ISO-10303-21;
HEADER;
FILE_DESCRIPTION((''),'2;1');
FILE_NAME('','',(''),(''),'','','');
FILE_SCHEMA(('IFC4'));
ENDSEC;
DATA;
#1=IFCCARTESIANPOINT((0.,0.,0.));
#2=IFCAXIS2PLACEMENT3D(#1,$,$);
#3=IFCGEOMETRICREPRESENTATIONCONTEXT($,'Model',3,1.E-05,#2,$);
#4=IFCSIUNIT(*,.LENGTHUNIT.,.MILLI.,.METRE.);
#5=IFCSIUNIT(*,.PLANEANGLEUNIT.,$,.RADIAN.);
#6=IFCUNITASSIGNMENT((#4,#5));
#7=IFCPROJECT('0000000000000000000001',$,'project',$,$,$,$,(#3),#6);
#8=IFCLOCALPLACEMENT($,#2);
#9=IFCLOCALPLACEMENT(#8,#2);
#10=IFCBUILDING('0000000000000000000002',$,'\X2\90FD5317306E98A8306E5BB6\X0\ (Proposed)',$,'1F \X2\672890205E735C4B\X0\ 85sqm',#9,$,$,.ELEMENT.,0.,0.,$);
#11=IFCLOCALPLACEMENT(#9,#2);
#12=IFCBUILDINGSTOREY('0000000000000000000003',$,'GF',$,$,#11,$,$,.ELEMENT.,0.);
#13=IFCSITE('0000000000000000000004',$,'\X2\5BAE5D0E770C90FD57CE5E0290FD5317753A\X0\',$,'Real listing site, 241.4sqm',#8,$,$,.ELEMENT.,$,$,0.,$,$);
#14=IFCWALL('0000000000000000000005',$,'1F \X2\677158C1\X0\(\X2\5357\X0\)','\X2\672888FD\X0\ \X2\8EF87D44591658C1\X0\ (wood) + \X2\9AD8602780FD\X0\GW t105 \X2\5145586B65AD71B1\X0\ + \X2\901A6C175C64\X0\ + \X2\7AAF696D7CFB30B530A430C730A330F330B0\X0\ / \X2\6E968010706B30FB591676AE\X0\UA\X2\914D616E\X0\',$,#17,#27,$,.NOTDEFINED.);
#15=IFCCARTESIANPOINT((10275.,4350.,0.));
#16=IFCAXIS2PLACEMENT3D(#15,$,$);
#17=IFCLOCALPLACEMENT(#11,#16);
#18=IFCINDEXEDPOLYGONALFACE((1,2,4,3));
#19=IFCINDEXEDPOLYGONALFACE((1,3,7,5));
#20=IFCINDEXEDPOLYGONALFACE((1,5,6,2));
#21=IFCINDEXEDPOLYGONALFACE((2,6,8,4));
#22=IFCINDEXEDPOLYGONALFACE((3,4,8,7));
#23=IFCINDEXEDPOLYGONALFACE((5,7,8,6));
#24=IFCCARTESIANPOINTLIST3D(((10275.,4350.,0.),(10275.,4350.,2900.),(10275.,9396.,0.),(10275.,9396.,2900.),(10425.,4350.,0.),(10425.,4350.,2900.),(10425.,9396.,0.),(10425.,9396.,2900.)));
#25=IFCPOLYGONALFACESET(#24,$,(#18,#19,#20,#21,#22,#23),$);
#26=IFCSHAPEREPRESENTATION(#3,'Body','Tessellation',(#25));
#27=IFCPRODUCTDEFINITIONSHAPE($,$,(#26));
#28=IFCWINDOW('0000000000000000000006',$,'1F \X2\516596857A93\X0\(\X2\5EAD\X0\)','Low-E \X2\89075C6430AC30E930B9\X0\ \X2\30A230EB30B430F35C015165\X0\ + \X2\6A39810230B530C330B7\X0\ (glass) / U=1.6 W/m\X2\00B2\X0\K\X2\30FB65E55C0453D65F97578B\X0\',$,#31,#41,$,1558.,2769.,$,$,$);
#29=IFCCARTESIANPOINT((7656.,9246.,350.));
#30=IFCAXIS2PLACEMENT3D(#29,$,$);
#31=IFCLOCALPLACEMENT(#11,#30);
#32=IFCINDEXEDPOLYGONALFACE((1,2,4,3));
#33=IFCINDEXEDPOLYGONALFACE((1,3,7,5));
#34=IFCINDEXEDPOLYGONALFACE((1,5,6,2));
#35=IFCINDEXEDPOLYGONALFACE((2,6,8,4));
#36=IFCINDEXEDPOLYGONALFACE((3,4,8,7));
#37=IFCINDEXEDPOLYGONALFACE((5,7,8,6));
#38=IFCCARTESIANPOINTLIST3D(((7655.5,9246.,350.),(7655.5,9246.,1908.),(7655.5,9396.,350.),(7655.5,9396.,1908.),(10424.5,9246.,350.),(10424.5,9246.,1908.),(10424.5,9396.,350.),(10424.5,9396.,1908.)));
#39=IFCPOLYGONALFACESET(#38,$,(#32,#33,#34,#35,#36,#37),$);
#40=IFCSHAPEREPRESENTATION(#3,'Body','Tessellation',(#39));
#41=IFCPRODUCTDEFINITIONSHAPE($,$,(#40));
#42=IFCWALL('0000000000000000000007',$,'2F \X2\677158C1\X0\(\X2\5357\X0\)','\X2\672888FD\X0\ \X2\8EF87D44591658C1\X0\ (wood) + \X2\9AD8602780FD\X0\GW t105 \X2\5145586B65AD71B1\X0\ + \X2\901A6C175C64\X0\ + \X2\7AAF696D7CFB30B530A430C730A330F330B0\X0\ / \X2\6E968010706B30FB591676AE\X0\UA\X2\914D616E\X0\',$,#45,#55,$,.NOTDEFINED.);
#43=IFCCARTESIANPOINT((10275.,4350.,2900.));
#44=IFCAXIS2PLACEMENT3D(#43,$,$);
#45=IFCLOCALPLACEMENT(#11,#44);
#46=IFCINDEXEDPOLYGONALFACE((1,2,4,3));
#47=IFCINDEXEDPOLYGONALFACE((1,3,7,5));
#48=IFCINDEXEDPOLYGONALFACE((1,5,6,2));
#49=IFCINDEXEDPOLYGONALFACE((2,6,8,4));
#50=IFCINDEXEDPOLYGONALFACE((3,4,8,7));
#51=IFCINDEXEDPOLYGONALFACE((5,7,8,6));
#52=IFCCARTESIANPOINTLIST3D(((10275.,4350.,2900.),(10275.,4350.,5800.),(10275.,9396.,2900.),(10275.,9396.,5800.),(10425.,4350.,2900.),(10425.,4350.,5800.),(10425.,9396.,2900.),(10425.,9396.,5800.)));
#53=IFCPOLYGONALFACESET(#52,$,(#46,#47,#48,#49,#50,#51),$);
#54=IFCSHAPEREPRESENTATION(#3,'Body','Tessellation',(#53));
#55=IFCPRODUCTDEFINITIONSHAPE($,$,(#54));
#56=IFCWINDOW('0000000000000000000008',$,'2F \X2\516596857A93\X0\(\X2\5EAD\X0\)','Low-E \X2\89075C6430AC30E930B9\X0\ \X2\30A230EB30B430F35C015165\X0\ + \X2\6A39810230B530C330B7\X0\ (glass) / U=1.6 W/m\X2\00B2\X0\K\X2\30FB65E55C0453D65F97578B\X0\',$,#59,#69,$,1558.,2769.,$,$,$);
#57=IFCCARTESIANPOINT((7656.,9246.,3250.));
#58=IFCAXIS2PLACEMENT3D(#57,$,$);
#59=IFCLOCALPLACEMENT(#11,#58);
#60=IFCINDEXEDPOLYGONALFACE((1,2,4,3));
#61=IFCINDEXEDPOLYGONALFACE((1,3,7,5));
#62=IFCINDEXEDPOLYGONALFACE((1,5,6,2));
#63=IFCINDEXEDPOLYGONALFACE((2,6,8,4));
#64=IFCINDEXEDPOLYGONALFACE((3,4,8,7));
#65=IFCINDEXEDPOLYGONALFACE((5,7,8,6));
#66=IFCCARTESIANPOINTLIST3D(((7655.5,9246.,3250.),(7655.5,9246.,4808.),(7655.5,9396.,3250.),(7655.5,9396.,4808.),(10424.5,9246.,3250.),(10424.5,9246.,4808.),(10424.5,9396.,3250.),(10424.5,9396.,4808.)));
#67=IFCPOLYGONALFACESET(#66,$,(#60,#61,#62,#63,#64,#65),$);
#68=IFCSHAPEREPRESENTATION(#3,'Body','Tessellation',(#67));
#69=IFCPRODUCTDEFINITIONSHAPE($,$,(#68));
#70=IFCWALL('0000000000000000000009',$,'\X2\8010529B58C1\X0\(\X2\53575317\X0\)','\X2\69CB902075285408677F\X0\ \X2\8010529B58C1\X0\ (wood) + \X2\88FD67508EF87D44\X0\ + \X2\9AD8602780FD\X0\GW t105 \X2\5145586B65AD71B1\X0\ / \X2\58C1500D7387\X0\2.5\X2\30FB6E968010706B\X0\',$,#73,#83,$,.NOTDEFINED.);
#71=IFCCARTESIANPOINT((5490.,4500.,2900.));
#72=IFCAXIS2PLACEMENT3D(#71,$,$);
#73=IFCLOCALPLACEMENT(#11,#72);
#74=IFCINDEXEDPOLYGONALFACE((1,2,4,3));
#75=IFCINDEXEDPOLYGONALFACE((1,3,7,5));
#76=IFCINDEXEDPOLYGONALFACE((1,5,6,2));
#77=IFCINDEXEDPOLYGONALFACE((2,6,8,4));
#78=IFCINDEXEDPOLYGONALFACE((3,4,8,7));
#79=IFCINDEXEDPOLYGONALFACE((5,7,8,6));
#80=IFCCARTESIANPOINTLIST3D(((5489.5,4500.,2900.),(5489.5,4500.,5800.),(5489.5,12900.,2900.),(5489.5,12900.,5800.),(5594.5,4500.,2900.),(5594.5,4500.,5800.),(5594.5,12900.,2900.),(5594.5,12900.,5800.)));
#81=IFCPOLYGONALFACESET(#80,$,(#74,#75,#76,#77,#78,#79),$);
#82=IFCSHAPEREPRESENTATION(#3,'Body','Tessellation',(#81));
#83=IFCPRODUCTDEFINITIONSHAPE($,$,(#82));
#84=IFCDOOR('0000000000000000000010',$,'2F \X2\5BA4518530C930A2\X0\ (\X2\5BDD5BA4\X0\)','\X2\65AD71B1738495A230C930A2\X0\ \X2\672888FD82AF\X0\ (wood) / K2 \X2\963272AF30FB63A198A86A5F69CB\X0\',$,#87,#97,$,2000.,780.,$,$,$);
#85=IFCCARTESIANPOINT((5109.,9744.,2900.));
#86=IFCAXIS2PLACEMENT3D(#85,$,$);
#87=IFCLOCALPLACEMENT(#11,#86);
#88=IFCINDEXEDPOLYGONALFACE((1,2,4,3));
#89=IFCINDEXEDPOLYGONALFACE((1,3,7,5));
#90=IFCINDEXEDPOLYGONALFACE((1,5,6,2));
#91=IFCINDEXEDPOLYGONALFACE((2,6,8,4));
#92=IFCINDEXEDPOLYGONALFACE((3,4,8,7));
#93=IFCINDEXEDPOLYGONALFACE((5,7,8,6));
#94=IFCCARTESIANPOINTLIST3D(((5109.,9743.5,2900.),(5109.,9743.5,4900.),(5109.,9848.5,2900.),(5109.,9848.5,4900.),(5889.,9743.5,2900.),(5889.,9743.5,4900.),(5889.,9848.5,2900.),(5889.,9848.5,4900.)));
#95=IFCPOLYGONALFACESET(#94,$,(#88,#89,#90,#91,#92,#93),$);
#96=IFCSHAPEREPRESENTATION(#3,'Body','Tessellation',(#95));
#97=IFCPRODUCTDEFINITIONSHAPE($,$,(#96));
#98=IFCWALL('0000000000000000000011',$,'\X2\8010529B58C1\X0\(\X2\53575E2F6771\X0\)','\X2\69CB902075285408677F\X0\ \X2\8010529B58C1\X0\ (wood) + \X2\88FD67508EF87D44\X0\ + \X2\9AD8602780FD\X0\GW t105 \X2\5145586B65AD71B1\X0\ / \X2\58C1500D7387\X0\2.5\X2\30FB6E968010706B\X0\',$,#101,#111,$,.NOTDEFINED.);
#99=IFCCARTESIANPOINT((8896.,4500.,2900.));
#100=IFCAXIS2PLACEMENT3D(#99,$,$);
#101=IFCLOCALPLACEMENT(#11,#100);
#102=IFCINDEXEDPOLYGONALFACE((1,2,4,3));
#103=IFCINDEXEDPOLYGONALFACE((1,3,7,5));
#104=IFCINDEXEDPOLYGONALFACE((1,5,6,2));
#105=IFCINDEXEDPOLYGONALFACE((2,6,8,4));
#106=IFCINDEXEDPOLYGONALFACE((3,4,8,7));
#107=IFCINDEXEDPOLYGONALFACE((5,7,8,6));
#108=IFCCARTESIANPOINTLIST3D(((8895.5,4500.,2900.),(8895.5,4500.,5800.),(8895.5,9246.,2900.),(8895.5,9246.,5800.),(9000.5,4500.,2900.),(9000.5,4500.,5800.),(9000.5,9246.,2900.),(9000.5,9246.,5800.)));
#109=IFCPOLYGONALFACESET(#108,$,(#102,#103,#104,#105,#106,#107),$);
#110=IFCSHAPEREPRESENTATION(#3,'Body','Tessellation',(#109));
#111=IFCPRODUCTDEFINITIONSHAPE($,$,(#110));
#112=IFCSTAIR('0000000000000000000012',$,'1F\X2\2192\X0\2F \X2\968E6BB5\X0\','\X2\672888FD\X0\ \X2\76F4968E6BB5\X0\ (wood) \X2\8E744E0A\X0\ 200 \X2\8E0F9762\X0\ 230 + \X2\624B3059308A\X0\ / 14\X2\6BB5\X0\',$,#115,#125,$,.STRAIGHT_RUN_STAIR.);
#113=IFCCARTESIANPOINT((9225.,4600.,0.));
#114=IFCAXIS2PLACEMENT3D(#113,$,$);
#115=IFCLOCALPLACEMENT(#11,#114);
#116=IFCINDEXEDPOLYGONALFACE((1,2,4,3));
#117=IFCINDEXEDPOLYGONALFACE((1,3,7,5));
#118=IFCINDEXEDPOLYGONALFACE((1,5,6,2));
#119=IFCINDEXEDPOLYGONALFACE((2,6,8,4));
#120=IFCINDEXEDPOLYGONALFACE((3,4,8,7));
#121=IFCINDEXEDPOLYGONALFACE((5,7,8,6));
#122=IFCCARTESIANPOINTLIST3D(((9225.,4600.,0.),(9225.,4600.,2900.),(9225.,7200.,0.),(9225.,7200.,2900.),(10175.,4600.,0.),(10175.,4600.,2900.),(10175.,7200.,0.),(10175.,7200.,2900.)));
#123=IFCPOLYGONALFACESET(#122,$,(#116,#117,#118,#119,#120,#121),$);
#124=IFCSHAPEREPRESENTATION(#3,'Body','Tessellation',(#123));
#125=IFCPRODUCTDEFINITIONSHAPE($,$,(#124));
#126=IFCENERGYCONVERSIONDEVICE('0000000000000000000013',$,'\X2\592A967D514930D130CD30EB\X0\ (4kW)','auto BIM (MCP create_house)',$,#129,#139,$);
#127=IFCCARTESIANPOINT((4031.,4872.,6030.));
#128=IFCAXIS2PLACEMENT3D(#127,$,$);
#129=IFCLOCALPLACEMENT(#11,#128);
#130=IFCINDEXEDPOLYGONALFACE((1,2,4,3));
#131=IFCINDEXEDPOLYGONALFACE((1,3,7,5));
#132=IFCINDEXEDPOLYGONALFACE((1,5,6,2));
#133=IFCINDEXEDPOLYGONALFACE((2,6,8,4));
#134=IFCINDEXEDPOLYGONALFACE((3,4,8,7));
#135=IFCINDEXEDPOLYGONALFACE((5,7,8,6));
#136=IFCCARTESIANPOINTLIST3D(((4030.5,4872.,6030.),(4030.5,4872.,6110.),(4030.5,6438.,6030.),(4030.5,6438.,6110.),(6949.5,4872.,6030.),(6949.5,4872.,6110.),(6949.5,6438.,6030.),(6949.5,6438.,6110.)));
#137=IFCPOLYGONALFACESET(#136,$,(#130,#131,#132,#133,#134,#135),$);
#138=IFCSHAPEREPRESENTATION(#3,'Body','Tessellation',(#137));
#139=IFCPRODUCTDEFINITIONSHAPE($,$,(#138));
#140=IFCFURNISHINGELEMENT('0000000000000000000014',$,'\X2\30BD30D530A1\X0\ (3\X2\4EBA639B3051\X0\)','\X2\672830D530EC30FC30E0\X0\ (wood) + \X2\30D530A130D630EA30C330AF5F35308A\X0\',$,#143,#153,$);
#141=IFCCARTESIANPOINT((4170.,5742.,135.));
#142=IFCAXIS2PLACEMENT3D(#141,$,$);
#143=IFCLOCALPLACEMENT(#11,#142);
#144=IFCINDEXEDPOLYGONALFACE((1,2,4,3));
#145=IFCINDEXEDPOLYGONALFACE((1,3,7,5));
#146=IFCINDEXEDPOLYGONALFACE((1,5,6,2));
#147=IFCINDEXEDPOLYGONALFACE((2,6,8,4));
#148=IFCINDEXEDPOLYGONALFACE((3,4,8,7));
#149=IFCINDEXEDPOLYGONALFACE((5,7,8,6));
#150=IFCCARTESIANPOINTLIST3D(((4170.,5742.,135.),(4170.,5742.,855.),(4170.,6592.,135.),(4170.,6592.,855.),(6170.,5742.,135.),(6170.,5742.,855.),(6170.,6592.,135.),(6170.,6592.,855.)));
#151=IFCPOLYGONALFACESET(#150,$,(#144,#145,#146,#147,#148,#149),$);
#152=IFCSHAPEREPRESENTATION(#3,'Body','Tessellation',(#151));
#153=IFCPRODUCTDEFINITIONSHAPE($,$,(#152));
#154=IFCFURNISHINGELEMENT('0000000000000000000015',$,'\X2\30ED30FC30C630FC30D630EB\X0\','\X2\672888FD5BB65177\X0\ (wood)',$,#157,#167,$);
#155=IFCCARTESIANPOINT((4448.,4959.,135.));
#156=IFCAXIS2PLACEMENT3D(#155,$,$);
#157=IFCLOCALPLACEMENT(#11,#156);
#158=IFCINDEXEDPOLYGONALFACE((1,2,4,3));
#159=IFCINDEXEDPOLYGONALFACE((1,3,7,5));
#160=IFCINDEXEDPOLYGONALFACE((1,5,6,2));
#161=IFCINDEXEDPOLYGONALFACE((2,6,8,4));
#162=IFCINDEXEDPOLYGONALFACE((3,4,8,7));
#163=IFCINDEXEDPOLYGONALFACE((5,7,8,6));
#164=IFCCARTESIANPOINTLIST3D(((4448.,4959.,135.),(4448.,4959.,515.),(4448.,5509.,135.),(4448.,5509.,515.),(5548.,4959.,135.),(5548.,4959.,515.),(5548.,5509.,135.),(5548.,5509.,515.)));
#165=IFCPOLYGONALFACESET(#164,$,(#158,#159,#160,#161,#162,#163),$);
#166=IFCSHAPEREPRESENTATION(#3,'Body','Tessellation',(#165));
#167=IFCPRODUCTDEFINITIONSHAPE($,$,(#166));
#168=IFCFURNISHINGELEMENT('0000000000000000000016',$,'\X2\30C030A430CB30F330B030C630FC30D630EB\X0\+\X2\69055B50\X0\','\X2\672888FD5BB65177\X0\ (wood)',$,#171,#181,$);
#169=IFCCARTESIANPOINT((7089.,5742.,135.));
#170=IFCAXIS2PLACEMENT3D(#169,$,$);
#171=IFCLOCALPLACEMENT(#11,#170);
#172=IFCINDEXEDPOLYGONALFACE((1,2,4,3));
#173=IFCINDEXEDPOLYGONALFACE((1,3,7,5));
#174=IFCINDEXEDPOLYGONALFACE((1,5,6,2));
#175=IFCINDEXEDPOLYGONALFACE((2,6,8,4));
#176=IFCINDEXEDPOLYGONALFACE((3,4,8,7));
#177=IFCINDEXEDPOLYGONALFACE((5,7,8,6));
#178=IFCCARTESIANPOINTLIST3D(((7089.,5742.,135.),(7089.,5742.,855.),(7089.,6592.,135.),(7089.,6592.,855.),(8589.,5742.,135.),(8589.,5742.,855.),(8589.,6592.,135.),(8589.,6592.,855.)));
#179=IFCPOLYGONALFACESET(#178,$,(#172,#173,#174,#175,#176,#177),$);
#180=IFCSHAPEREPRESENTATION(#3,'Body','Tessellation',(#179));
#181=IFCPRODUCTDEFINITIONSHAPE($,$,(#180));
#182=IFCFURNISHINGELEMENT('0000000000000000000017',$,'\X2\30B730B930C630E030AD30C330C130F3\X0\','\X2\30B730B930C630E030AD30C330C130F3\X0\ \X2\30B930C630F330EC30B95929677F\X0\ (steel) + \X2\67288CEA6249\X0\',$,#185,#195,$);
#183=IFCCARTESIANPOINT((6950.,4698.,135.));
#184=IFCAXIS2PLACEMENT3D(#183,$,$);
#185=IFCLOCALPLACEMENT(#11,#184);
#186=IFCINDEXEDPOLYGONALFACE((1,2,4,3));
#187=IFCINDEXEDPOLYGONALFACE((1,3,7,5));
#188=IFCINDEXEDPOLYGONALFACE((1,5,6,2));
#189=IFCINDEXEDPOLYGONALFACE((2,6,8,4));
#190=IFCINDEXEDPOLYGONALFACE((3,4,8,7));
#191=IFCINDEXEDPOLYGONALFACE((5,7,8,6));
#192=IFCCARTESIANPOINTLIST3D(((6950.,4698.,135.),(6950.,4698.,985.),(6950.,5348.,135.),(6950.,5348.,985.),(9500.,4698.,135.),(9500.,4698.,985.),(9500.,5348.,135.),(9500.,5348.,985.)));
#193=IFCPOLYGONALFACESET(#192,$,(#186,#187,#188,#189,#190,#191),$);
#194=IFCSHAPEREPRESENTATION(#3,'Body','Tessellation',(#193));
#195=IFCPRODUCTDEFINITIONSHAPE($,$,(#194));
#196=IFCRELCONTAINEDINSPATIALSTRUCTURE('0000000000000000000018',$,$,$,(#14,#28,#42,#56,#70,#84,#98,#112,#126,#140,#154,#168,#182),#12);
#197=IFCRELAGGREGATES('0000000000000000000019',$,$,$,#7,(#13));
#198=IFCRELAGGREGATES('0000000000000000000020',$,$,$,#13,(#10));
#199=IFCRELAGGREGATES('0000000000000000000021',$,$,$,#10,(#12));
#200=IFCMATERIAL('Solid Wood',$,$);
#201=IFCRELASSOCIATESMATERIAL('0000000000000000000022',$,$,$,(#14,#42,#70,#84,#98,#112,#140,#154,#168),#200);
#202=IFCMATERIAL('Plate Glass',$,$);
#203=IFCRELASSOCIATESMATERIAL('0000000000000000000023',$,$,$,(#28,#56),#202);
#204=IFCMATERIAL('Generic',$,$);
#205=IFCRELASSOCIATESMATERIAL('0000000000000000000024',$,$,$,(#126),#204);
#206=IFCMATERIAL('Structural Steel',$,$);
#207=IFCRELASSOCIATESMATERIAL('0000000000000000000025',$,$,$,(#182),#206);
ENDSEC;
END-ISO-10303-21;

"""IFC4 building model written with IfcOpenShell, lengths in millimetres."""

from ifc_helpers import new_model, si_unit, frame, frame_2d, origin, place, context, project, spatial, rectangle, extrude, material, element, fill, save


model = new_model("IFC4")

# Units and contexts
model_context = context("Model", 3, precision=1e-05, world=origin())
ifc_project = project(units=[si_unit("LENGTHUNIT", "METRE", prefix="MILLI"), si_unit("PLANEANGLEUNIT", "RADIAN")], contexts=[model_context])

# Site, building, storey
site_placement = place(None, origin())
site = spatial("IfcSite", under=ifc_project, at=site_placement, Name="宮崎県都城市都北町", ObjectType="Real listing site, 241.4sqm", CompositionType="ELEMENT", RefElevation=0.0)
building_placement = place(site_placement, origin())
building = spatial("IfcBuilding", under=site, at=building_placement, Name="都北の風の家 (Proposed)", ObjectType="1F 木造平屋 85sqm", CompositionType="ELEMENT", ElevationOfRefHeight=0.0, ElevationOfTerrain=0.0)
storey_placement = place(building_placement, origin())
storey = spatial("IfcBuildingStorey", under=building, at=storey_placement, Name="GF", CompositionType="ELEMENT", Elevation=0.0)

# Wall, opening, window
ifc_material_1 = material(Name="Solid Wood")
wall_1_placement = place(storey_placement, frame((10275.0, 4350.0, 0.0)))
wall_1 = element("IfcWall", 1, at=wall_1_placement, inside=storey, material=ifc_material_1, Name="1F 東壁(南)", Description="木製 軸組外壁 (wood) + 高性能GW t105 充填断熱 + 通気層 + 窯業系サイディング / 準耐火・外皮UA配慮", PredefinedType="NOTDEFINED", context=model_context, shape_type="SweptSolid", body=[
    extrude(rectangle(XDim=150.0, YDim=5046.0, at=frame_2d((75.0, 2523.0))), frame((10275.0, 4350.0, 0.0)), (0.0, 0.0, 1.0), 2900.0),
])
opening_1_placement = place(storey_placement, frame((7656.0, 9246.0, 350.0)))
opening_1 = element("IfcOpeningElement", 2, at=opening_1_placement, cuts=wall_1, PredefinedType="NOTDEFINED", context=model_context, shape_type="SweptSolid", body=[
    extrude(rectangle(XDim=2769.0, YDim=150.0, at=frame_2d((1384.0, 75.0))), frame((7656.0, 9246.0, 350.0)), (0.0, 0.0, 1.0), 1558.0),
])
ifc_material_2 = material(Name="Plate Glass")
window_1_placement = place(storey_placement, frame((7656.0, 9246.0, 350.0)))
window_1 = element("IfcWindow", 3, at=window_1_placement, inside=storey, material=ifc_material_2, Name="1F 入隅窓(庭)", Description="Low-E 複層ガラス アルゴン封入 + 樹脂サッシ (glass) / U=1.6 W/m²K・日射取得型", OverallHeight=1558.0, OverallWidth=2769.0, context=model_context, shape_type="SweptSolid", body=[
    extrude(rectangle(XDim=2769.0, YDim=150.0, at=frame_2d((1384.0, 75.0))), frame((7656.0, 9246.0, 350.0)), (0.0, 0.0, 1.0), 1558.0),
])
fill(opening_1, window_1)

# Wall, opening, window
wall_2_placement = place(storey_placement, frame((10275.0, 4350.0, 2900.0)))
wall_2 = element("IfcWall", 4, at=wall_2_placement, inside=storey, material=ifc_material_1, Name="2F 東壁(南)", Description="木製 軸組外壁 (wood) + 高性能GW t105 充填断熱 + 通気層 + 窯業系サイディング / 準耐火・外皮UA配慮", PredefinedType="NOTDEFINED", context=model_context, shape_type="SweptSolid", body=[
    extrude(rectangle(XDim=150.0, YDim=5046.0, at=frame_2d((75.0, 2523.0))), frame((10275.0, 4350.0, 2900.0)), (0.0, 0.0, 1.0), 2900.0),
])
opening_2_placement = place(storey_placement, frame((7656.0, 9246.0, 3250.0)))
opening_2 = element("IfcOpeningElement", 5, at=opening_2_placement, cuts=wall_2, PredefinedType="NOTDEFINED", context=model_context, shape_type="SweptSolid", body=[
    extrude(rectangle(XDim=2769.0, YDim=150.0, at=frame_2d((1384.0, 75.0))), frame((7656.0, 9246.0, 3250.0)), (0.0, 0.0, 1.0), 1558.0),
])
window_2_placement = place(storey_placement, frame((7656.0, 9246.0, 3250.0)))
window_2 = element("IfcWindow", 6, at=window_2_placement, inside=storey, material=ifc_material_2, Name="2F 入隅窓(庭)", Description="Low-E 複層ガラス アルゴン封入 + 樹脂サッシ (glass) / U=1.6 W/m²K・日射取得型", OverallHeight=1558.0, OverallWidth=2769.0, context=model_context, shape_type="SweptSolid", body=[
    extrude(rectangle(XDim=2769.0, YDim=150.0, at=frame_2d((1384.0, 75.0))), frame((7656.0, 9246.0, 3250.0)), (0.0, 0.0, 1.0), 1558.0),
])
fill(opening_2, window_2)

# Wall, opening, door
wall_3_placement = place(storey_placement, frame((5490.0, 4500.0, 2900.0)))
wall_3 = element("IfcWall", 7, at=wall_3_placement, inside=storey, material=ifc_material_1, Name="耐力壁(南北)", Description="構造用合板 耐力壁 (wood) + 製材軸組 + 高性能GW t105 充填断熱 / 壁倍率2.5・準耐火", PredefinedType="NOTDEFINED", context=model_context, shape_type="SweptSolid", body=[
    extrude(rectangle(XDim=105.0, YDim=8400.0, at=frame_2d((52.0, 4200.0))), frame((5490.0, 4500.0, 2900.0)), (0.0, 0.0, 1.0), 2900.0),
])
opening_3_placement = place(storey_placement, frame((5109.0, 9744.0, 2900.0)))
opening_3 = element("IfcOpeningElement", 8, at=opening_3_placement, cuts=wall_3, PredefinedType="NOTDEFINED", context=model_context, shape_type="SweptSolid", body=[
    extrude(rectangle(XDim=780.0, YDim=105.0, at=frame_2d((390.0, 52.0))), frame((5109.0, 9744.0, 2900.0)), (0.0, 0.0, 1.0), 2000.0),
])
door_1_placement = place(storey_placement, frame((5109.0, 9744.0, 2900.0)))
door_1 = element("IfcDoor", 9, at=door_1_placement, inside=storey, material=ifc_material_1, Name="2F 室内ドア (寝室)", Description="断熱玄関ドア 木製芯 (wood) / K2 防犯・採風機構", OverallHeight=2000.0, OverallWidth=780.0, context=model_context, shape_type="SweptSolid", body=[
    extrude(rectangle(XDim=780.0, YDim=105.0, at=frame_2d((390.0, 52.0))), frame((5109.0, 9744.0, 2900.0)), (0.0, 0.0, 1.0), 2000.0),
])
fill(opening_3, door_1)

# Wall
wall_4_placement = place(storey_placement, frame((8896.0, 4500.0, 2900.0)))
element("IfcWall", 10, at=wall_4_placement, inside=storey, material=ifc_material_1, Name="耐力壁(南帯東)", Description="構造用合板 耐力壁 (wood) + 製材軸組 + 高性能GW t105 充填断熱 / 壁倍率2.5・準耐火", PredefinedType="NOTDEFINED", context=model_context, shape_type="SweptSolid", body=[
    extrude(rectangle(XDim=105.0, YDim=4746.0, at=frame_2d((52.0, 2373.0))), frame((8896.0, 4500.0, 2900.0)), (0.0, 0.0, 1.0), 2900.0),
])

# Stair
stair_placement = place(storey_placement, frame((9225.0, 4600.0, 0.0)))
element("IfcStair", 11, at=stair_placement, inside=storey, material=ifc_material_1, Name="1F→2F 階段", Description="木製 直階段 (wood) 蹴上 200 踏面 230 + 手すり / 14段", PredefinedType="STRAIGHT_RUN_STAIR", context=model_context, shape_type="SweptSolid", body=[
    extrude(rectangle(XDim=950.0, YDim=2600.0, at=frame_2d((475.0, 1300.0))), frame((9225.0, 4600.0, 0.0)), (0.0, 0.0, 1.0), 2900.0),
])

# Energy conversion device
ifc_material_3 = material(Name="Generic")
energy_conversion_device_placement = place(storey_placement, frame((4031.0, 4872.0, 6030.0)))
element("IfcEnergyConversionDevice", 12, at=energy_conversion_device_placement, inside=storey, material=ifc_material_3, Name="太陽光パネル (4kW)", Description="auto BIM (MCP create_house)", context=model_context, shape_type="SweptSolid", body=[
    extrude(rectangle(XDim=2919.0, YDim=1566.0, at=frame_2d((1459.0, 783.0))), frame((4031.0, 4872.0, 6030.0)), (0.0, 0.0, 1.0), 80.0),
])

# Furnishing elements
furnishing_1_placement = place(storey_placement, frame((4170.0, 5742.0, 135.0)))
element("IfcFurnishingElement", 13, at=furnishing_1_placement, inside=storey, material=ifc_material_1, Name="ソファ (3人掛け)", Description="木フレーム (wood) + ファブリック張り", context=model_context, shape_type="SweptSolid", body=[
    extrude(rectangle(XDim=2000.0, YDim=850.0, at=frame_2d((1000.0, 425.0))), frame((4170.0, 5742.0, 135.0)), (0.0, 0.0, 1.0), 720.0),
])
furnishing_2_placement = place(storey_placement, frame((4448.0, 4959.0, 135.0)))
element("IfcFurnishingElement", 14, at=furnishing_2_placement, inside=storey, material=ifc_material_1, Name="ローテーブル", Description="木製家具 (wood)", context=model_context, shape_type="SweptSolid", body=[
    extrude(rectangle(XDim=1100.0, YDim=550.0, at=frame_2d((550.0, 275.0))), frame((4448.0, 4959.0, 135.0)), (0.0, 0.0, 1.0), 380.0),
])
furnishing_3_placement = place(storey_placement, frame((7089.0, 5742.0, 135.0)))
element("IfcFurnishingElement", 15, at=furnishing_3_placement, inside=storey, material=ifc_material_1, Name="ダイニングテーブル+椅子", Description="木製家具 (wood)", context=model_context, shape_type="SweptSolid", body=[
    extrude(rectangle(XDim=1500.0, YDim=850.0, at=frame_2d((750.0, 425.0))), frame((7089.0, 5742.0, 135.0)), (0.0, 0.0, 1.0), 720.0),
])
ifc_material_4 = material(Name="Structural Steel")
furnishing_4_placement = place(storey_placement, frame((6950.0, 4698.0, 135.0)))
element("IfcFurnishingElement", 16, at=furnishing_4_placement, inside=storey, material=ifc_material_4, Name="システムキッチン", Description="システムキッチン ステンレス天板 (steel) + 木質扉", context=model_context, shape_type="SweptSolid", body=[
    extrude(rectangle(XDim=2550.0, YDim=650.0, at=frame_2d((1275.0, 325.0))), frame((6950.0, 4698.0, 135.0)), (0.0, 0.0, 1.0), 850.0),
])

save(model, "model.ifc")
